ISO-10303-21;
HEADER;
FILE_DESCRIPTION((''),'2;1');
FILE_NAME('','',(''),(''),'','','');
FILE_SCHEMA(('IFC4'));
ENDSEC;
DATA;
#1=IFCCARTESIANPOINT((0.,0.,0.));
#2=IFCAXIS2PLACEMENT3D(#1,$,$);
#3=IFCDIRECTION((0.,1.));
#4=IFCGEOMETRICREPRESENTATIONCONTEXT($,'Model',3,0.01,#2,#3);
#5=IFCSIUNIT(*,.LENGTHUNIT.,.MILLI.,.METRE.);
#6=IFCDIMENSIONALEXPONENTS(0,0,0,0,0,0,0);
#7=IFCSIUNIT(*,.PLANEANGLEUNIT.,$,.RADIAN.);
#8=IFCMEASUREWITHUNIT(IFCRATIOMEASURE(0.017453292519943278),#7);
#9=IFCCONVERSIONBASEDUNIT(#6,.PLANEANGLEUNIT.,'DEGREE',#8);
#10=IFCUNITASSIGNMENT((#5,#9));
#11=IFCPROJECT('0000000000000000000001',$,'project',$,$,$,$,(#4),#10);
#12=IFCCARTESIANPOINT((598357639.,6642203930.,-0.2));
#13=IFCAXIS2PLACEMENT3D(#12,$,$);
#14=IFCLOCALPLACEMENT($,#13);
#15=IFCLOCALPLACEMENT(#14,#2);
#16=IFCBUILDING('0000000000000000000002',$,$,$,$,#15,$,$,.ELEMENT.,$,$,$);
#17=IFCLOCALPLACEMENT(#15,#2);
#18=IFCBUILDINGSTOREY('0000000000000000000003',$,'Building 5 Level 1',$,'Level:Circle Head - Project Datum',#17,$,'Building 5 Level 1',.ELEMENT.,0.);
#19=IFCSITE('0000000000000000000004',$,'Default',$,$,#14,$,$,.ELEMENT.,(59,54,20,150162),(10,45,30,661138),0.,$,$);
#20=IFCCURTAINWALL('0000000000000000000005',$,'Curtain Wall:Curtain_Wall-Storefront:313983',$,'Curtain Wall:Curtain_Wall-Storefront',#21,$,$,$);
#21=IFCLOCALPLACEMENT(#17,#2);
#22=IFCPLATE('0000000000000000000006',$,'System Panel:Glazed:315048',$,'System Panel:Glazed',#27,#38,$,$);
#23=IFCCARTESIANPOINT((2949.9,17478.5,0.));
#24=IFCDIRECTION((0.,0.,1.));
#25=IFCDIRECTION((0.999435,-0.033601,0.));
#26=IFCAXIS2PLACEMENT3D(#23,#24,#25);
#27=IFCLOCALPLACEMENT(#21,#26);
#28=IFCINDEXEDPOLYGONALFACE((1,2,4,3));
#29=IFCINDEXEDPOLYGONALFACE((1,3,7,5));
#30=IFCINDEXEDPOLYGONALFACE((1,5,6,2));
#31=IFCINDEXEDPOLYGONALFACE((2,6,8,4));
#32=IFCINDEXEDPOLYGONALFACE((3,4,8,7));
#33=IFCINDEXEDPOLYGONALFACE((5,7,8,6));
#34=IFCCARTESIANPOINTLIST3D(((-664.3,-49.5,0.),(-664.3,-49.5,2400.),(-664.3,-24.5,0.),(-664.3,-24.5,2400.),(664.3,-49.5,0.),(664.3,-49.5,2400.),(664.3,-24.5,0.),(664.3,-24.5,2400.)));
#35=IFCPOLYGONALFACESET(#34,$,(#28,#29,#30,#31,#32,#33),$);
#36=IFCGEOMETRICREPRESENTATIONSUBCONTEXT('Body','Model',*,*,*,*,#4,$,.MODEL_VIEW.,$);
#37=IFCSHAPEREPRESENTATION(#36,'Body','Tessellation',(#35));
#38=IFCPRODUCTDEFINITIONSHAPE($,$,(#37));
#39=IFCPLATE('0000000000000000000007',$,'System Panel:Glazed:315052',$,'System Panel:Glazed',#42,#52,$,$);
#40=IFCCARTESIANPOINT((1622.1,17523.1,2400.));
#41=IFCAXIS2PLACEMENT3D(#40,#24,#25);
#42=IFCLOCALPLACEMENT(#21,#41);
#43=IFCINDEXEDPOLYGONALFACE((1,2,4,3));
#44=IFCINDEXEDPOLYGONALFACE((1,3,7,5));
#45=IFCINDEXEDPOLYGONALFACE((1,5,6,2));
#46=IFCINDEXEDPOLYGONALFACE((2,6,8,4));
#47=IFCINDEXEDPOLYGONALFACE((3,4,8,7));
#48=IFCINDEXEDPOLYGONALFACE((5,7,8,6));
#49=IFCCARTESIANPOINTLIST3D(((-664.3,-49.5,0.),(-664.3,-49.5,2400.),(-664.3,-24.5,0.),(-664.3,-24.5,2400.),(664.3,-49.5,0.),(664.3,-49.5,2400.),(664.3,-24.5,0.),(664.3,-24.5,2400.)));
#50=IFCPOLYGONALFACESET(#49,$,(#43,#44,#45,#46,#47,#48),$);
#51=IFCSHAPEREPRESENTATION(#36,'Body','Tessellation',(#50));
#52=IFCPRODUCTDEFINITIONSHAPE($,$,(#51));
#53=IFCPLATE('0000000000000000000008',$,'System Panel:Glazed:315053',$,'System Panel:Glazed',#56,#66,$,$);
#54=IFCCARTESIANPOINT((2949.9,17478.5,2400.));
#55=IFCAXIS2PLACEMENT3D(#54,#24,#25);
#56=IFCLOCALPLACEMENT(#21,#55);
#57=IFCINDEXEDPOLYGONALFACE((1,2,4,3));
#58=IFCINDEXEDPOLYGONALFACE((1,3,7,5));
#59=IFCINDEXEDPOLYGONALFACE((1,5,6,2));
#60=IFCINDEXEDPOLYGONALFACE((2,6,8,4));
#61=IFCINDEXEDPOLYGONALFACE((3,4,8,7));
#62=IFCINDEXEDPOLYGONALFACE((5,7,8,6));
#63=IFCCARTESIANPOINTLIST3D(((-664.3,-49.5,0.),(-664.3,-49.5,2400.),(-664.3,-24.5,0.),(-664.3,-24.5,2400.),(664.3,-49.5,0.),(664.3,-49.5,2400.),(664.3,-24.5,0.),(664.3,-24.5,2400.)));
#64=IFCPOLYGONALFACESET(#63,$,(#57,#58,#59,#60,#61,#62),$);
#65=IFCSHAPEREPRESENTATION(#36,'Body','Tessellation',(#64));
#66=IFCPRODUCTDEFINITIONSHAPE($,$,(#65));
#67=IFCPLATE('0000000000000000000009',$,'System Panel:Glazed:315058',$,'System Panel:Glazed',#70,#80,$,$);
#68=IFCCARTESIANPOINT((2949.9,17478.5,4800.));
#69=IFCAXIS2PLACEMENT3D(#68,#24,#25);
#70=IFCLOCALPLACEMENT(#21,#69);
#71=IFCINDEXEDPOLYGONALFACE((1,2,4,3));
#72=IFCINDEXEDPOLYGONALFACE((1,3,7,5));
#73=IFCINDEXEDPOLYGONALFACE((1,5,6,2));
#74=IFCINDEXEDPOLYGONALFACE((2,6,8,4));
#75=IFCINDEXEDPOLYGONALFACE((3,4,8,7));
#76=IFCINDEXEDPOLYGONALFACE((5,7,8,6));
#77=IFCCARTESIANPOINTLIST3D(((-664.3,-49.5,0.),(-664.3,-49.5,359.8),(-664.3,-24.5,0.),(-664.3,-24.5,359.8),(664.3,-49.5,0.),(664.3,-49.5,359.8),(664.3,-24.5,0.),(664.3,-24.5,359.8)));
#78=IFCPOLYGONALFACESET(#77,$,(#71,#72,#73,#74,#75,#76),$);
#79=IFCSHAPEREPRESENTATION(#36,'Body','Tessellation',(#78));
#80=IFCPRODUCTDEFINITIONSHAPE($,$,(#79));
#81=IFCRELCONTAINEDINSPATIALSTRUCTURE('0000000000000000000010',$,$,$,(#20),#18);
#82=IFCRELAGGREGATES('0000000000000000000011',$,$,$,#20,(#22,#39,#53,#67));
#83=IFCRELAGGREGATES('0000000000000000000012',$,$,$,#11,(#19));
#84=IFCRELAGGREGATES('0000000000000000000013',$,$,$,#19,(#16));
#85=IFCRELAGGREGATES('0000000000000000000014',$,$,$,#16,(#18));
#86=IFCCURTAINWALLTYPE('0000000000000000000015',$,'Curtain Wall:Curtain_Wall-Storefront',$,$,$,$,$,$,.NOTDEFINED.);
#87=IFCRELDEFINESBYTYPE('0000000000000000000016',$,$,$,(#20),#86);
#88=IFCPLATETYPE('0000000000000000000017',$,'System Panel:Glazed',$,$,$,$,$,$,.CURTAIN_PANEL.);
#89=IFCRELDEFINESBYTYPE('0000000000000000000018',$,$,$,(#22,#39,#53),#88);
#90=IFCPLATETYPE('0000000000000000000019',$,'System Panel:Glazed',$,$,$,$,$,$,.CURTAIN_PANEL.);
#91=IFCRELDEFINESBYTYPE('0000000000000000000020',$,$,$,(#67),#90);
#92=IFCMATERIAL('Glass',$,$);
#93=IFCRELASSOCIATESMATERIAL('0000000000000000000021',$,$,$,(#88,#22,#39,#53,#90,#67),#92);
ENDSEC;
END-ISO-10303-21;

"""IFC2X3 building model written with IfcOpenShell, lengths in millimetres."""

from ifc_helpers import new_model, entity, si_unit, converted_unit, direction, frame, frame_2d, origin, place, context, subcontext, project, spatial, rectangle, extrude, source, transform, mapped, material, type_object, type_shapes, element, aggregate, save


model = new_model("IFC2X3")

# Units and contexts
model_context = context("Model", 3, precision=0.01, world=origin(), true_north=direction((0.0, 1.0)))
body_context = subcontext(model_context, "Body", "Model", "MODEL_VIEW")
ifc_project = project(units=[si_unit("LENGTHUNIT", "METRE", prefix="MILLI"), converted_unit("PLANEANGLEUNIT", "DEGREE", entity("IfcRatioMeasure", 0.017453292519943278), si_unit("PLANEANGLEUNIT", "RADIAN"), dimensions=[0, 0, 0, 0, 0, 0, 0])], contexts=[model_context])

# Site, building, storey
site_placement = place(None, frame((598357639.0, 6642203930.0, -0.2)))
site = spatial("IfcSite", under=ifc_project, at=site_placement, Name="Default", CompositionType="ELEMENT", RefLatitude=(59, 54, 20, 150162), RefLongitude=(10, 45, 30, 661138), RefElevation=0.0)
building_placement = place(site_placement, origin())
building = spatial("IfcBuilding", under=site, at=building_placement, CompositionType="ELEMENT")
storey_placement = place(building_placement, origin())
storey = spatial("IfcBuildingStorey", under=building, at=storey_placement, Name="Building 5 Level 1", ObjectType="Level:Circle Head - Project Datum", LongName="Building 5 Level 1", CompositionType="ELEMENT", Elevation=0.0)

# Curtain wall, plates
curtain_wall_type = type_object("IfcCurtainWallType", Name="Curtain Wall:Curtain_Wall-Storefront", PredefinedType="NOTDEFINED")
ifc_material_1 = material(Name="Glass")
curtain_wall_1_placement = place(storey_placement, origin())
curtain_wall_1 = element("IfcCurtainWall", 1, at=curtain_wall_1_placement, inside=storey, type_object=curtain_wall_type, Name="Curtain Wall:Curtain_Wall-Storefront:313983", ObjectType="Curtain Wall:Curtain_Wall-Storefront")
plate_type_1 = type_object("IfcPlateType", Name="System Panel:Glazed", PredefinedType="CURTAIN_PANEL", material=ifc_material_1)
shared_shape_1 = source(origin(), body_context, "Body", "SweptSolid", [
    extrude(rectangle(XDim=25.0, YDim=1328.6, at=frame_2d((0.0, 0.0), x_axis=(1.0, 0.0))), frame((0.0, -37.0, 0.0), z_axis=(0.0, 0.0, 1.0), x_axis=(0.0, 1.0, 0.0)), (0.0, 0.0, 1.0), 2400.0),
])
type_shapes(plate_type_1, [shared_shape_1])
plate_1_placement = place(curtain_wall_1_placement, frame((2949.9, 17478.5, 0.0), z_axis=(0.0, 0.0, 1.0), x_axis=(0.999435, -0.033601, 0.0)))
plate_1 = element("IfcPlate", 2, at=plate_1_placement, type_object=plate_type_1, material=ifc_material_1, Name="System Panel:Glazed:315048", ObjectType="System Panel:Glazed", context=body_context, shape_type="MappedRepresentation", body=[
    mapped(shared_shape_1, transform((0.0, 0.0, 0.0), scale=1.0)),
])
plate_2_placement = place(curtain_wall_1_placement, frame((1622.1, 17523.1, 2400.0), z_axis=(0.0, 0.0, 1.0), x_axis=(0.999435, -0.033601, 0.0)))
plate_2 = element("IfcPlate", 3, at=plate_2_placement, type_object=plate_type_1, material=ifc_material_1, Name="System Panel:Glazed:315052", ObjectType="System Panel:Glazed", context=body_context, shape_type="MappedRepresentation", body=[
    mapped(shared_shape_1, transform((0.0, 0.0, 0.0), scale=1.0)),
])
plate_3_placement = place(curtain_wall_1_placement, frame((2949.9, 17478.5, 2400.0), z_axis=(0.0, 0.0, 1.0), x_axis=(0.999435, -0.033601, 0.0)))
plate_3 = element("IfcPlate", 4, at=plate_3_placement, type_object=plate_type_1, material=ifc_material_1, Name="System Panel:Glazed:315053", ObjectType="System Panel:Glazed", context=body_context, shape_type="MappedRepresentation", body=[
    mapped(shared_shape_1, transform((0.0, 0.0, 0.0), scale=1.0)),
])
plate_type_2 = type_object("IfcPlateType", Name="System Panel:Glazed", PredefinedType="CURTAIN_PANEL", material=ifc_material_1)
shared_shape_2 = source(origin(), body_context, "Body", "SweptSolid", [
    extrude(rectangle(XDim=25.0, YDim=1328.6, at=frame_2d((0.0, 0.0), x_axis=(1.0, 0.0))), frame((0.0, -37.0, 0.0), z_axis=(0.0, 0.0, 1.0), x_axis=(0.0, 1.0, 0.0)), (0.0, 0.0, 1.0), 359.8),
])
type_shapes(plate_type_2, [shared_shape_2])
plate_4_placement = place(curtain_wall_1_placement, frame((2949.9, 17478.5, 4800.0), z_axis=(0.0, 0.0, 1.0), x_axis=(0.999435, -0.033601, 0.0)))
plate_4 = element("IfcPlate", 5, at=plate_4_placement, type_object=plate_type_2, material=ifc_material_1, Name="System Panel:Glazed:315058", ObjectType="System Panel:Glazed", context=body_context, shape_type="MappedRepresentation", body=[
    mapped(shared_shape_2, transform((0.0, 0.0, 0.0), scale=1.0)),
])
aggregate(curtain_wall_1, [plate_1, plate_2, plate_3, plate_4])

save(model, "model.ifc")
